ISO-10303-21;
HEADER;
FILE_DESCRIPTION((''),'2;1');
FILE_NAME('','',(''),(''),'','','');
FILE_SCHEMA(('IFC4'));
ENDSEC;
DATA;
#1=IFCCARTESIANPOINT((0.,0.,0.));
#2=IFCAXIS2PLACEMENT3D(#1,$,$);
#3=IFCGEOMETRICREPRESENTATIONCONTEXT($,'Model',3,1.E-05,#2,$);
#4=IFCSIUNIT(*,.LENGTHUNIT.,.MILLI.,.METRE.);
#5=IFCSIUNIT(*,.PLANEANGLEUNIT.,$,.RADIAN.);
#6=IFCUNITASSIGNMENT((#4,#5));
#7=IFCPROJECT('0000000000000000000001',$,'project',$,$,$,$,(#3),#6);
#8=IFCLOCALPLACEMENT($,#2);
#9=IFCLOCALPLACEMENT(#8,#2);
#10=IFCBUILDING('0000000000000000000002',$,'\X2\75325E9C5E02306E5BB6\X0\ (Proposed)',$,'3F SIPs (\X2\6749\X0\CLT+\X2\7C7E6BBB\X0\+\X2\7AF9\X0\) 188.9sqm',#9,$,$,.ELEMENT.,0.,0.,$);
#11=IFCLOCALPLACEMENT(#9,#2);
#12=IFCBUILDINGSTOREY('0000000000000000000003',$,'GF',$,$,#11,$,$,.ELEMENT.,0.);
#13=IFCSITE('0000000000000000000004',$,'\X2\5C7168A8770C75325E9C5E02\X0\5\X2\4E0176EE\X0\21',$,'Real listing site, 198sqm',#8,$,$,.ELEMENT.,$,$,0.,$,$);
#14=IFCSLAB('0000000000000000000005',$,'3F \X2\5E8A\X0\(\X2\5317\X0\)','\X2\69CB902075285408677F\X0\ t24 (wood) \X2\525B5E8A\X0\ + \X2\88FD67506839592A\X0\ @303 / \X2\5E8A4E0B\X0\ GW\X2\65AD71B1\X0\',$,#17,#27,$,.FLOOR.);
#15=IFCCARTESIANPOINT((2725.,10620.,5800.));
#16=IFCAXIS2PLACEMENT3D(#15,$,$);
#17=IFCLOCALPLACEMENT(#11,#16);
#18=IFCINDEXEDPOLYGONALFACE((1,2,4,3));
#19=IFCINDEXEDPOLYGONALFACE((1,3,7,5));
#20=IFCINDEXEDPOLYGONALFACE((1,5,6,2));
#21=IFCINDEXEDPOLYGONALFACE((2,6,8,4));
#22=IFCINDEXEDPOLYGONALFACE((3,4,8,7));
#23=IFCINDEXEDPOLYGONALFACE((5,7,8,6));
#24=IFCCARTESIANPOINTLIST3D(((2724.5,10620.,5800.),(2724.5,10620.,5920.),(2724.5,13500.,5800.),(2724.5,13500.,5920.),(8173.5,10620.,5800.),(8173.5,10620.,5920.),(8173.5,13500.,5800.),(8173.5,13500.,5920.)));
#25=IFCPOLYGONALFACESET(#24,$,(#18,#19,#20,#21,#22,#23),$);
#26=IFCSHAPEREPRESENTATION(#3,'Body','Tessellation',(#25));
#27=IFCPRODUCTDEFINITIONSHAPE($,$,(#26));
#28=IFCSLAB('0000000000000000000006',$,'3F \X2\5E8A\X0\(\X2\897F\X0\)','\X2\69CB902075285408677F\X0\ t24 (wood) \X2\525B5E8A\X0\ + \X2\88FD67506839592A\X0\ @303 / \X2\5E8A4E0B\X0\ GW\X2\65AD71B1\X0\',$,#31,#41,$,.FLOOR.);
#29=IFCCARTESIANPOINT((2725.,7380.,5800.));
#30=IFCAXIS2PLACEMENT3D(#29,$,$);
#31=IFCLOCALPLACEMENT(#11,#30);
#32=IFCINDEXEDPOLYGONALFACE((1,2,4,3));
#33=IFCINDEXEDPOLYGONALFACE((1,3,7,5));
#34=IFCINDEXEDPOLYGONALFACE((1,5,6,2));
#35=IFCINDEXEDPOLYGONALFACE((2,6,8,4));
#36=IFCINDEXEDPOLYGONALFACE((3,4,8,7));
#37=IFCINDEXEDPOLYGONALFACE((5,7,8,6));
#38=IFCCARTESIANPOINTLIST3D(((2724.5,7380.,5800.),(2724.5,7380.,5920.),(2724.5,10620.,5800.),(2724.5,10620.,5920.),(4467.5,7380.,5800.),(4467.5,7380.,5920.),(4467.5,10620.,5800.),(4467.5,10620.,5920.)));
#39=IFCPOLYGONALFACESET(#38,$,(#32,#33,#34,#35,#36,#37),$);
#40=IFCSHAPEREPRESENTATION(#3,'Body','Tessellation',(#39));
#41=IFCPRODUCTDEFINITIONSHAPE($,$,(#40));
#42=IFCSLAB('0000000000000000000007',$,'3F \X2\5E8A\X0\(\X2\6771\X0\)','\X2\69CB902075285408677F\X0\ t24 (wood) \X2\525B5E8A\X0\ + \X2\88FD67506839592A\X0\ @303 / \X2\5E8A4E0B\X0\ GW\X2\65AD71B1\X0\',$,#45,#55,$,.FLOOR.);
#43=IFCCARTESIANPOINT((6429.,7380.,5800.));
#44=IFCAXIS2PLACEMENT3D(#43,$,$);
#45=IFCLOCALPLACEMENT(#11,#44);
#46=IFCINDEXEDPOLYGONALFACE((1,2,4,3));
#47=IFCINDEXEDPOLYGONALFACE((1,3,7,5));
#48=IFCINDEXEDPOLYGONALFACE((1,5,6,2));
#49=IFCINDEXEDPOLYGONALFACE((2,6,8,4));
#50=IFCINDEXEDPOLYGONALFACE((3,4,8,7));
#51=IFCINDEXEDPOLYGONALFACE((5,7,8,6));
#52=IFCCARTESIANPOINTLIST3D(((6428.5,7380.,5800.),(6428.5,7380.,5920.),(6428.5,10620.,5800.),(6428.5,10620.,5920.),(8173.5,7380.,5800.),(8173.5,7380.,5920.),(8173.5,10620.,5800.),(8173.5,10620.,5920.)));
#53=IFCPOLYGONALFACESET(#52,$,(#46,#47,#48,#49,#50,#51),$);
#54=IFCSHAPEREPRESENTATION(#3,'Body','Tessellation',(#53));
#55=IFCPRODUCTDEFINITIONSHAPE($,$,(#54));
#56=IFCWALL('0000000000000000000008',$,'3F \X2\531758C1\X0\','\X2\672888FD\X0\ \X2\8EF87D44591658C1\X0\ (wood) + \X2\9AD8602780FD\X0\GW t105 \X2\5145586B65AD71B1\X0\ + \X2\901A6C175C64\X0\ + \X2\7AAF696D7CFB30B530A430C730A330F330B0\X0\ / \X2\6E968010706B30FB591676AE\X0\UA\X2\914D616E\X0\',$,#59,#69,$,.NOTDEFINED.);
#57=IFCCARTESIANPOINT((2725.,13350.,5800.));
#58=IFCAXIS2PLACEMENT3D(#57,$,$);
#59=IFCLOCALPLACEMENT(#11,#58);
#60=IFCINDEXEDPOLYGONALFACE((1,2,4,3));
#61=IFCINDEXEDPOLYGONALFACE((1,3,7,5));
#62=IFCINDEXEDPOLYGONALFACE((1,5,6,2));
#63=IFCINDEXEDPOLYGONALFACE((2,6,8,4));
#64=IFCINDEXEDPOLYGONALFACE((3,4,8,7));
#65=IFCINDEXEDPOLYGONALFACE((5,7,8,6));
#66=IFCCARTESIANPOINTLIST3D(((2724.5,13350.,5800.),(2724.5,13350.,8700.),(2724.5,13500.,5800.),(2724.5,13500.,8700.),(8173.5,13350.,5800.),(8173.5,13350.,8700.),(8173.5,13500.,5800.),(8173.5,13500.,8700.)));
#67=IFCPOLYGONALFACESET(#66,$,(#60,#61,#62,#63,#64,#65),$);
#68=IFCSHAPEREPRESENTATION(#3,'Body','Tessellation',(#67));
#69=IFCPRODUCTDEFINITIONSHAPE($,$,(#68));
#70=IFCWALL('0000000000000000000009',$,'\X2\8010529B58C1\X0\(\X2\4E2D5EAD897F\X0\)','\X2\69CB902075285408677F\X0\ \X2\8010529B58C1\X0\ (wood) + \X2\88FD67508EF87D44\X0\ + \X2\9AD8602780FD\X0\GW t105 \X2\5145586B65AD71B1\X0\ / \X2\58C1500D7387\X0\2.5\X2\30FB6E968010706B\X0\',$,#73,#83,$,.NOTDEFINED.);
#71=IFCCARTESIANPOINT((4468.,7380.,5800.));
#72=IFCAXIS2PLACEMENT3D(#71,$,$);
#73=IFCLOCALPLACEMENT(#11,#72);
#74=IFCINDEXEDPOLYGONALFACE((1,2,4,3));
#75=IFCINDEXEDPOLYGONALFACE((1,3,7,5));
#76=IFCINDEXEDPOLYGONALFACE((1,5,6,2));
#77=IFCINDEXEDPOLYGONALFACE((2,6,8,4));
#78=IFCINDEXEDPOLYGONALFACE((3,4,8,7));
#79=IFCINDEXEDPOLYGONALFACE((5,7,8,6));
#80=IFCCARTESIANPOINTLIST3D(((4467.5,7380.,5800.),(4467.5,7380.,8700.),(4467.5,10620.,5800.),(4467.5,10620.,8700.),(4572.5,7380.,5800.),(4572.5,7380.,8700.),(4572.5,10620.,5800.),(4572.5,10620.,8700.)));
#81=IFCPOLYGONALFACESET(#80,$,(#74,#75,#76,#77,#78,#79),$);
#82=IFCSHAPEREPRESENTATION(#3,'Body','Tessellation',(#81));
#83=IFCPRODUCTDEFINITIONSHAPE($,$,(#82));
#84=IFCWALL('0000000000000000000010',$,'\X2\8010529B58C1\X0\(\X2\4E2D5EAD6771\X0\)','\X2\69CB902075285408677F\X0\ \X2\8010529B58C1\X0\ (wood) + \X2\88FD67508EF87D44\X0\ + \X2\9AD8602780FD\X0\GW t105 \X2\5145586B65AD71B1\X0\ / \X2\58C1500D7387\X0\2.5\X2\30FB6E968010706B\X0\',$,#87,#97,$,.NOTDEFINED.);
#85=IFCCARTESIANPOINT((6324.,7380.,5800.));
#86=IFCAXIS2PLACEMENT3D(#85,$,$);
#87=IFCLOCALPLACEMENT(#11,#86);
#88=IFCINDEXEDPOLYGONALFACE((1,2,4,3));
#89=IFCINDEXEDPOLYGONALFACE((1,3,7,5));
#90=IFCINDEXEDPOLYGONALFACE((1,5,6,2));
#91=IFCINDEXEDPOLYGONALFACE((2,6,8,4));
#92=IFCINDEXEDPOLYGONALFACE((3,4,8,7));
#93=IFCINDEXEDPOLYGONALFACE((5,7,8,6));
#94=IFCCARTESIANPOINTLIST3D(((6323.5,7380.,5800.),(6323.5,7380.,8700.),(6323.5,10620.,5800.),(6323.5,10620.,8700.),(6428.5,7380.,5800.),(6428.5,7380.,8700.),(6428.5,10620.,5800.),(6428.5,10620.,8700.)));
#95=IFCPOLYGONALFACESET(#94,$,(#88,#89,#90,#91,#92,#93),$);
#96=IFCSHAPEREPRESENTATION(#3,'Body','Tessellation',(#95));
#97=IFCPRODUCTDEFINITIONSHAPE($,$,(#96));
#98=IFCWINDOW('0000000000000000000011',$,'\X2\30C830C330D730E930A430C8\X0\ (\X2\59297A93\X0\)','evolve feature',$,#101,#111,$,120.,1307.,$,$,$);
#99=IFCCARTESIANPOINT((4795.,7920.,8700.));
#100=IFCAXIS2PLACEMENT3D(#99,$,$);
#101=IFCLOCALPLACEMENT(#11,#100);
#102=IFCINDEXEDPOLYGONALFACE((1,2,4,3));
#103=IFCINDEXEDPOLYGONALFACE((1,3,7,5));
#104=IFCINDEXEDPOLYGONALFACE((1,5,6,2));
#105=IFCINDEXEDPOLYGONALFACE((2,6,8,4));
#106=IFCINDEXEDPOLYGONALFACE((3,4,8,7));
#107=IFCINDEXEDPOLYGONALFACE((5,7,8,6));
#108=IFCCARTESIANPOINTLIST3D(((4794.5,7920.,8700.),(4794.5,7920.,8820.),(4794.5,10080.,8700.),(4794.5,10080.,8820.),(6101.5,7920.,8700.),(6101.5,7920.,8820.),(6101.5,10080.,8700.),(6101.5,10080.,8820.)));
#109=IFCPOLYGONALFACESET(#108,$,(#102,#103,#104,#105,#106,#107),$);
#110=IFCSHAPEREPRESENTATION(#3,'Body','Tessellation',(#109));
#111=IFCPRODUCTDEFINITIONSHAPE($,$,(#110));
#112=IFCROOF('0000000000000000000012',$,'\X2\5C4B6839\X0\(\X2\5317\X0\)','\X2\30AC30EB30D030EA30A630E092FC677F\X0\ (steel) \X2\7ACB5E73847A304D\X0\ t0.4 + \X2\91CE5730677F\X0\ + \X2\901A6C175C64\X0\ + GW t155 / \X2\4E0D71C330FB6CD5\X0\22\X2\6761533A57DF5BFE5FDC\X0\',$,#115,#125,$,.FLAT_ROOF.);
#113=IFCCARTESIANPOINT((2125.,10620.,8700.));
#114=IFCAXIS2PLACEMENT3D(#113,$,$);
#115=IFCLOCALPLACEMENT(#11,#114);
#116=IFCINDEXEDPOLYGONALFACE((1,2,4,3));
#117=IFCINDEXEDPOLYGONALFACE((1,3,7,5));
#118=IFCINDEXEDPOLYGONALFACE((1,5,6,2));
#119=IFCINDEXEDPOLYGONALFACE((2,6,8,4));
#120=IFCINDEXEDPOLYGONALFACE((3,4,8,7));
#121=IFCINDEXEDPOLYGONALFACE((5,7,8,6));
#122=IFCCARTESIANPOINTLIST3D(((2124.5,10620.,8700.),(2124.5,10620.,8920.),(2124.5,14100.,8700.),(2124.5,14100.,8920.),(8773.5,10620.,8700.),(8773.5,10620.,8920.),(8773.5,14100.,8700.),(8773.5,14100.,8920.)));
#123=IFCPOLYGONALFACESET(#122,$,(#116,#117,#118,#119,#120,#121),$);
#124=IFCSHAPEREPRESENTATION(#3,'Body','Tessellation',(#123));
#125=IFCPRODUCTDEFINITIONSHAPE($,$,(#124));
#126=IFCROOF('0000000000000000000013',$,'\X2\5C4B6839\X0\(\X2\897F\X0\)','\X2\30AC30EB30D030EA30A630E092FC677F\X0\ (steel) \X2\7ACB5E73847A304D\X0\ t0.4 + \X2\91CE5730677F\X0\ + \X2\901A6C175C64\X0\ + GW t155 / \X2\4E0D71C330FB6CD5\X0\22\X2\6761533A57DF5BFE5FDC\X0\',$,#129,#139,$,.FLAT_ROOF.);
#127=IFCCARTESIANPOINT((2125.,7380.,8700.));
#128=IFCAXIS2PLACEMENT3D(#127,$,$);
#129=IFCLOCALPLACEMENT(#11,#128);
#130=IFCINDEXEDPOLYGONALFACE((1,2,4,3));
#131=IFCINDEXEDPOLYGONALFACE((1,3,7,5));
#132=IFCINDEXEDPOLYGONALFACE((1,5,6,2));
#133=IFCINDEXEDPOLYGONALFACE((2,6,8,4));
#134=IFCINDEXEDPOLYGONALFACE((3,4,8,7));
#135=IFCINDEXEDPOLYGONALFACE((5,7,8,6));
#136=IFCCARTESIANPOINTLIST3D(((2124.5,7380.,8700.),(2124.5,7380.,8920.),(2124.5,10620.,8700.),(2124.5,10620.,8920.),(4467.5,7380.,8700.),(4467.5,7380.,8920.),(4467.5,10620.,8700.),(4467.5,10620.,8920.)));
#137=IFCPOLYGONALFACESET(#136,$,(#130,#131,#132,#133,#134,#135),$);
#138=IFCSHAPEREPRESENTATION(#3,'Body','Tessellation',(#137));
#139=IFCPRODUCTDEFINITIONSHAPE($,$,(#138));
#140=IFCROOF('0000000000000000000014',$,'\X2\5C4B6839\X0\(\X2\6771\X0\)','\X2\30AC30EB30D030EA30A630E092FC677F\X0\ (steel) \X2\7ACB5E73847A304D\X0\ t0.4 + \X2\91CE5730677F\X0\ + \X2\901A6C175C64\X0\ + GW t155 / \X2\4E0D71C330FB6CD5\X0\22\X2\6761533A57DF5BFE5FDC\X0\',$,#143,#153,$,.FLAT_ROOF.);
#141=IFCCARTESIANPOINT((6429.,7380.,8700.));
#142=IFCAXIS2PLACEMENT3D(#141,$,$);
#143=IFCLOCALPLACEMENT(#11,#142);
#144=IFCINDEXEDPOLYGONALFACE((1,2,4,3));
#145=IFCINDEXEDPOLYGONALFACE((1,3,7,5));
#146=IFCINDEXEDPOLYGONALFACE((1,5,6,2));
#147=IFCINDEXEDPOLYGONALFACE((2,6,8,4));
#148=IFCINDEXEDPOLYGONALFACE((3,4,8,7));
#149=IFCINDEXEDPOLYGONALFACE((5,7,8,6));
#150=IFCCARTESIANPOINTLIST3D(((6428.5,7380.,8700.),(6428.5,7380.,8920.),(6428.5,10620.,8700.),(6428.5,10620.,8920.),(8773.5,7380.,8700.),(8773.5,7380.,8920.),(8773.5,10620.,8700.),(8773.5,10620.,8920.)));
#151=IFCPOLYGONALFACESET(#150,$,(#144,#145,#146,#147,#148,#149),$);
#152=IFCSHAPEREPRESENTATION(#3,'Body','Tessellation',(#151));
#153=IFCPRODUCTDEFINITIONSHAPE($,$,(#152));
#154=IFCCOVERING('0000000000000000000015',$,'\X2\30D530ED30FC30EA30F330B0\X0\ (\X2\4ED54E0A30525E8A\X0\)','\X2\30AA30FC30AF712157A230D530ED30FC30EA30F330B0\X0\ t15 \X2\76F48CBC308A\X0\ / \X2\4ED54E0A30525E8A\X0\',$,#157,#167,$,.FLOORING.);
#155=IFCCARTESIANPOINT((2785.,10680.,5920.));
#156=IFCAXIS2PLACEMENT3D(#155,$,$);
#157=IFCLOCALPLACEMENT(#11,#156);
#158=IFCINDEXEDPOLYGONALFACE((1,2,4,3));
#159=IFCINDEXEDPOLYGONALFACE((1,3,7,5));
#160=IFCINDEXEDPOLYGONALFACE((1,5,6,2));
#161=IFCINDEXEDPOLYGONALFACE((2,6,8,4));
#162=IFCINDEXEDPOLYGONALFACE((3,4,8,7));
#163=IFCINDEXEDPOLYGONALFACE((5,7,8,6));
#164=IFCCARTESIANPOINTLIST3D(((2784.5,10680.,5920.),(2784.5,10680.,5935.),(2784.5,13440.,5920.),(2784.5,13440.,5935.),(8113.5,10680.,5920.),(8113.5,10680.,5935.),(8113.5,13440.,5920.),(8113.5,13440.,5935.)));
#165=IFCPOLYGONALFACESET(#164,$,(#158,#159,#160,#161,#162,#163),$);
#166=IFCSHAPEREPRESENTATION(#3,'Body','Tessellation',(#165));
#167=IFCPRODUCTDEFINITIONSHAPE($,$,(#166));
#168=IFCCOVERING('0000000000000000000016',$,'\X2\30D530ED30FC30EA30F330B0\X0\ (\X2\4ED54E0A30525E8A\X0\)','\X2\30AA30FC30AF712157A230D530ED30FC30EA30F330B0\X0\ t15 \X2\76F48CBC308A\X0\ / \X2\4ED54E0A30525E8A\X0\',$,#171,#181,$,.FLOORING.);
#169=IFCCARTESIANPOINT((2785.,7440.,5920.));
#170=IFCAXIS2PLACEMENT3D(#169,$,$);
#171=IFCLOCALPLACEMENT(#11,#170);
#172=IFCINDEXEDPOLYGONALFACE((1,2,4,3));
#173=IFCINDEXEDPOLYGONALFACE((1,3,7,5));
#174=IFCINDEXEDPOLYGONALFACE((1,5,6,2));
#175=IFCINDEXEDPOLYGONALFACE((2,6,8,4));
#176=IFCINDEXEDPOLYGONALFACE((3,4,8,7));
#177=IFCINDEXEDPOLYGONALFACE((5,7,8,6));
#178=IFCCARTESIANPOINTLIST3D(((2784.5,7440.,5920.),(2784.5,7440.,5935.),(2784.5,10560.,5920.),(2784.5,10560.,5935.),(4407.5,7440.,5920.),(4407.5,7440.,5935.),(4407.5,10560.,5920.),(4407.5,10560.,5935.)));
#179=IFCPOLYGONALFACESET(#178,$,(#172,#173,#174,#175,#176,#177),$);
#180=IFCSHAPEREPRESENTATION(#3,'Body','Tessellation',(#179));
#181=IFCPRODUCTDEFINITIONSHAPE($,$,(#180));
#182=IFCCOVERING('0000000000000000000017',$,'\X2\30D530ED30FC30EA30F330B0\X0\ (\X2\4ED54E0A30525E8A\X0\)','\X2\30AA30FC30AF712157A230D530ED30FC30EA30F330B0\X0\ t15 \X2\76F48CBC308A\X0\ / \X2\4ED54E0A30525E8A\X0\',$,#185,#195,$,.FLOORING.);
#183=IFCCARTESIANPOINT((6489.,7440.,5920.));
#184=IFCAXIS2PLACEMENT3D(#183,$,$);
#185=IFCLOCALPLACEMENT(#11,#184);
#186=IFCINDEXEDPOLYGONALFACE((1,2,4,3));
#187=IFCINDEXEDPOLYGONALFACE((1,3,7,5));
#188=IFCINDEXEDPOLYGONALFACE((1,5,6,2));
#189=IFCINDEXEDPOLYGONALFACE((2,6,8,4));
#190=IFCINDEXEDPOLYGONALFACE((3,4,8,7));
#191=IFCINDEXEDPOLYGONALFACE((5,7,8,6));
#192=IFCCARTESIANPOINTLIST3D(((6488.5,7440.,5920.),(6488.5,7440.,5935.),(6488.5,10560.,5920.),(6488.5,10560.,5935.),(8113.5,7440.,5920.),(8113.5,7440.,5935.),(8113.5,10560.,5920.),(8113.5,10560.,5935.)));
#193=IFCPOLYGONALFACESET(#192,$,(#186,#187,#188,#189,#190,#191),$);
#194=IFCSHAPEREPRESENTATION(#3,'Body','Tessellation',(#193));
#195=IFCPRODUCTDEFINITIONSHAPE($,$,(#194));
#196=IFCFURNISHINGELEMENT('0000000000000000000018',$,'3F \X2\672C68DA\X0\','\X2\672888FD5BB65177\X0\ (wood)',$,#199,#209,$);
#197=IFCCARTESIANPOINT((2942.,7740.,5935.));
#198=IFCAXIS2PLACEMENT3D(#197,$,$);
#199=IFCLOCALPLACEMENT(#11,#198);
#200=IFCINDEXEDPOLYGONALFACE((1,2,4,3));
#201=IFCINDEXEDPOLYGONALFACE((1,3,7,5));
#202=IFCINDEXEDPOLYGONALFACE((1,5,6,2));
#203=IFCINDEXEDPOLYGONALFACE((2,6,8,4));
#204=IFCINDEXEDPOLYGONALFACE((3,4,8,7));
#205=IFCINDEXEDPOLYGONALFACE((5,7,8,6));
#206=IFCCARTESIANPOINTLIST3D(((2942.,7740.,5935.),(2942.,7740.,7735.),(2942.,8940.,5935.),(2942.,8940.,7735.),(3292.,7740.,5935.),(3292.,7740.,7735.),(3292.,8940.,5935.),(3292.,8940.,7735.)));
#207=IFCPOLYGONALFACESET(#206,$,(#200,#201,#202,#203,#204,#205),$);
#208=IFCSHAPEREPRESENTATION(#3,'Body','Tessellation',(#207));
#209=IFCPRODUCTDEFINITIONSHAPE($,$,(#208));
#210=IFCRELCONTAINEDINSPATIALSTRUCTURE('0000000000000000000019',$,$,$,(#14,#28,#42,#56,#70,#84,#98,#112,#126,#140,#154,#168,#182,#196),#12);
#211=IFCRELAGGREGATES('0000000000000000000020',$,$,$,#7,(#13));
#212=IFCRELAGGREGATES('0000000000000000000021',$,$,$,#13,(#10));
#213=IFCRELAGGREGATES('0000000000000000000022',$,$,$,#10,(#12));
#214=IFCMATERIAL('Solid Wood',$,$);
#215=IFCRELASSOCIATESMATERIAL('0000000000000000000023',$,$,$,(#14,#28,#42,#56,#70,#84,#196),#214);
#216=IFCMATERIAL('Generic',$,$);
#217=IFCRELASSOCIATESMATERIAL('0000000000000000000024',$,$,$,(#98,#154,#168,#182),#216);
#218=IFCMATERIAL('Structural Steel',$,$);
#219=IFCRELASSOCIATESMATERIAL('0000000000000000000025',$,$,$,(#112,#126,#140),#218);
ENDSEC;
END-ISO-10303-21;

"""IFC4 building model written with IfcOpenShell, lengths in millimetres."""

from ifc_helpers import new_model, si_unit, frame, frame_2d, origin, place, context, project, spatial, rectangle, extrude, material, element, save


model = new_model("IFC4")

# Units and contexts
model_context = context("Model", 3, precision=1e-05, world=origin())
ifc_project = project(units=[si_unit("LENGTHUNIT", "METRE", prefix="MILLI"), si_unit("PLANEANGLEUNIT", "RADIAN")], contexts=[model_context])

# Site, building, storey
site_placement = place(None, origin())
site = spatial("IfcSite", under=ifc_project, at=site_placement, Name="山梨県甲府市5丁目21", ObjectType="Real listing site, 198sqm", CompositionType="ELEMENT", RefElevation=0.0)
building_placement = place(site_placement, origin())
building = spatial("IfcBuilding", under=site, at=building_placement, Name="甲府市の家 (Proposed)", ObjectType="3F SIPs (杉CLT+籾殻+竹) 188.9sqm", CompositionType="ELEMENT", ElevationOfRefHeight=0.0, ElevationOfTerrain=0.0)
storey_placement = place(building_placement, origin())
storey = spatial("IfcBuildingStorey", under=building, at=storey_placement, Name="GF", CompositionType="ELEMENT", Elevation=0.0)

# Slabs
ifc_material_1 = material(Name="Solid Wood")
slab_1_placement = place(storey_placement, frame((2725.0, 10620.0, 5800.0)))
element("IfcSlab", 1, at=slab_1_placement, inside=storey, material=ifc_material_1, Name="3F 床(北)", Description="構造用合板 t24 (wood) 剛床 + 製材根太 @303 / 床下 GW断熱", PredefinedType="FLOOR", context=model_context, shape_type="SweptSolid", body=[
    extrude(rectangle(XDim=5449.0, YDim=2880.0, at=frame_2d((2724.0, 1440.0))), frame((2725.0, 10620.0, 5800.0)), (0.0, 0.0, 1.0), 120.0),
])
slab_2_placement = place(storey_placement, frame((2725.0, 7380.0, 5800.0)))
element("IfcSlab", 2, at=slab_2_placement, inside=storey, material=ifc_material_1, Name="3F 床(西)", Description="構造用合板 t24 (wood) 剛床 + 製材根太 @303 / 床下 GW断熱", PredefinedType="FLOOR", context=model_context, shape_type="SweptSolid", body=[
    extrude(rectangle(XDim=1743.0, YDim=3240.0, at=frame_2d((871.0, 1620.0))), frame((2725.0, 7380.0, 5800.0)), (0.0, 0.0, 1.0), 120.0),
])
slab_3_placement = place(storey_placement, frame((6429.0, 7380.0, 5800.0)))
element("IfcSlab", 3, at=slab_3_placement, inside=storey, material=ifc_material_1, Name="3F 床(東)", Description="構造用合板 t24 (wood) 剛床 + 製材根太 @303 / 床下 GW断熱", PredefinedType="FLOOR", context=model_context, shape_type="SweptSolid", body=[
    extrude(rectangle(XDim=1745.0, YDim=3240.0, at=frame_2d((872.0, 1620.0))), frame((6429.0, 7380.0, 5800.0)), (0.0, 0.0, 1.0), 120.0),
])

# Wall
wall_1_placement = place(storey_placement, frame((2725.0, 13350.0, 5800.0)))
element("IfcWall", 4, at=wall_1_placement, inside=storey, material=ifc_material_1, Name="3F 北壁", Description="木製 軸組外壁 (wood) + 高性能GW t105 充填断熱 + 通気層 + 窯業系サイディング / 準耐火・外皮UA配慮", PredefinedType="NOTDEFINED", context=model_context, shape_type="SweptSolid", body=[
    extrude(rectangle(XDim=5449.0, YDim=150.0, at=frame_2d((2724.0, 75.0))), frame((2725.0, 13350.0, 5800.0)), (0.0, 0.0, 1.0), 2900.0),
])

# Walls
wall_2_placement = place(storey_placement, frame((4468.0, 7380.0, 5800.0)))
element("IfcWall", 5, at=wall_2_placement, inside=storey, material=ifc_material_1, Name="耐力壁(中庭西)", Description="構造用合板 耐力壁 (wood) + 製材軸組 + 高性能GW t105 充填断熱 / 壁倍率2.5・準耐火", PredefinedType="NOTDEFINED", context=model_context, shape_type="SweptSolid", body=[
    extrude(rectangle(XDim=105.0, YDim=3240.0, at=frame_2d((52.0, 1620.0))), frame((4468.0, 7380.0, 5800.0)), (0.0, 0.0, 1.0), 2900.0),
])
wall_3_placement = place(storey_placement, frame((6324.0, 7380.0, 5800.0)))
element("IfcWall", 6, at=wall_3_placement, inside=storey, material=ifc_material_1, Name="耐力壁(中庭東)", Description="構造用合板 耐力壁 (wood) + 製材軸組 + 高性能GW t105 充填断熱 / 壁倍率2.5・準耐火", PredefinedType="NOTDEFINED", context=model_context, shape_type="SweptSolid", body=[
    extrude(rectangle(XDim=105.0, YDim=3240.0, at=frame_2d((52.0, 1620.0))), frame((6324.0, 7380.0, 5800.0)), (0.0, 0.0, 1.0), 2900.0),
])

# Window
ifc_material_2 = material(Name="Generic")
window_1_placement = place(storey_placement, frame((4795.0, 7920.0, 8700.0)))
element("IfcWindow", 7, at=window_1_placement, inside=storey, material=ifc_material_2, Name="トップライト (天窓)", Description="evolve feature", OverallHeight=120.0, OverallWidth=1307.0, context=model_context, shape_type="SweptSolid", body=[
    extrude(rectangle(XDim=1307.0, YDim=2160.0, at=frame_2d((653.0, 1080.0))), frame((4795.0, 7920.0, 8700.0)), (0.0, 0.0, 1.0), 120.0),
])

# Roofs
ifc_material_3 = material(Name="Structural Steel")
for number, where, name in (
    (8, (2125.0, 10620.0, 8700.0), "屋根(北)"),
):
    element("IfcRoof", number, at=place(storey_placement, frame(where)), inside=storey, material=ifc_material_3, Name=name, Description="ガルバリウム鋼板 (steel) 立平葺き t0.4 + 野地板 + 通気層 + GW t155 / 不燃・法22条区域対応", PredefinedType="FLAT_ROOF", context=model_context, shape_type="SweptSolid", body=[
        extrude(rectangle(XDim=6649.0, YDim=3480.0, at=frame_2d((3324.0, 1740.0))), frame((2125.0, 10620.0, 8700.0)), (0.0, 0.0, 1.0), 220.0),
    ])
roof_1_placement = place(storey_placement, frame((2125.0, 7380.0, 8700.0)))
element("IfcRoof", 9, at=roof_1_placement, inside=storey, material=ifc_material_3, Name="屋根(西)", Description="ガルバリウム鋼板 (steel) 立平葺き t0.4 + 野地板 + 通気層 + GW t155 / 不燃・法22条区域対応", PredefinedType="FLAT_ROOF", context=model_context, shape_type="SweptSolid", body=[
    extrude(rectangle(XDim=2343.0, YDim=3240.0, at=frame_2d((1171.0, 1620.0))), frame((2125.0, 7380.0, 8700.0)), (0.0, 0.0, 1.0), 220.0),
])
roof_2_placement = place(storey_placement, frame((6429.0, 7380.0, 8700.0)))
element("IfcRoof", 10, at=roof_2_placement, inside=storey, material=ifc_material_3, Name="屋根(東)", Description="ガルバリウム鋼板 (steel) 立平葺き t0.4 + 野地板 + 通気層 + GW t155 / 不燃・法22条区域対応", PredefinedType="FLAT_ROOF", context=model_context, shape_type="SweptSolid", body=[
    extrude(rectangle(XDim=2345.0, YDim=3240.0, at=frame_2d((1172.0, 1620.0))), frame((6429.0, 7380.0, 8700.0)), (0.0, 0.0, 1.0), 220.0),
])

# Coverings
covering_1_placement = place(storey_placement, frame((2785.0, 10680.0, 5920.0)))
element("IfcCovering", 11, at=covering_1_placement, inside=storey, material=ifc_material_2, Name="フローリング (仕上げ床)", Description="オーク無垢フローリング t15 直貼り / 仕上げ床", PredefinedType="FLOORING", context=model_context, shape_type="SweptSolid", body=[
    extrude(rectangle(XDim=5329.0, YDim=2760.0, at=frame_2d((2664.0, 1380.0))), frame((2785.0, 10680.0, 5920.0)), (0.0, 0.0, 1.0), 15.0),
])
covering_2_placement = place(storey_placement, frame((2785.0, 7440.0, 5920.0)))
element("IfcCovering", 12, at=covering_2_placement, inside=storey, material=ifc_material_2, Name="フローリング (仕上げ床)", Description="オーク無垢フローリング t15 直貼り / 仕上げ床", PredefinedType="FLOORING", context=model_context, shape_type="SweptSolid", body=[
    extrude(rectangle(XDim=1623.0, YDim=3120.0, at=frame_2d((811.0, 1560.0))), frame((2785.0, 7440.0, 5920.0)), (0.0, 0.0, 1.0), 15.0),
])
covering_3_placement = place(storey_placement, frame((6489.0, 7440.0, 5920.0)))
element("IfcCovering", 13, at=covering_3_placement, inside=storey, material=ifc_material_2, Name="フローリング (仕上げ床)", Description="オーク無垢フローリング t15 直貼り / 仕上げ床", PredefinedType="FLOORING", context=model_context, shape_type="SweptSolid", body=[
    extrude(rectangle(XDim=1625.0, YDim=3120.0, at=frame_2d((812.0, 1560.0))), frame((6489.0, 7440.0, 5920.0)), (0.0, 0.0, 1.0), 15.0),
])

# Furnishing element
furnishing_placement = place(storey_placement, frame((2942.0, 7740.0, 5935.0)))
element("IfcFurnishingElement", 14, at=furnishing_placement, inside=storey, material=ifc_material_1, Name="3F 本棚", Description="木製家具 (wood)", context=model_context, shape_type="SweptSolid", body=[
    extrude(rectangle(XDim=350.0, YDim=1200.0, at=frame_2d((175.0, 600.0))), frame((2942.0, 7740.0, 5935.0)), (0.0, 0.0, 1.0), 1800.0),
])

save(model, "model.ifc")
